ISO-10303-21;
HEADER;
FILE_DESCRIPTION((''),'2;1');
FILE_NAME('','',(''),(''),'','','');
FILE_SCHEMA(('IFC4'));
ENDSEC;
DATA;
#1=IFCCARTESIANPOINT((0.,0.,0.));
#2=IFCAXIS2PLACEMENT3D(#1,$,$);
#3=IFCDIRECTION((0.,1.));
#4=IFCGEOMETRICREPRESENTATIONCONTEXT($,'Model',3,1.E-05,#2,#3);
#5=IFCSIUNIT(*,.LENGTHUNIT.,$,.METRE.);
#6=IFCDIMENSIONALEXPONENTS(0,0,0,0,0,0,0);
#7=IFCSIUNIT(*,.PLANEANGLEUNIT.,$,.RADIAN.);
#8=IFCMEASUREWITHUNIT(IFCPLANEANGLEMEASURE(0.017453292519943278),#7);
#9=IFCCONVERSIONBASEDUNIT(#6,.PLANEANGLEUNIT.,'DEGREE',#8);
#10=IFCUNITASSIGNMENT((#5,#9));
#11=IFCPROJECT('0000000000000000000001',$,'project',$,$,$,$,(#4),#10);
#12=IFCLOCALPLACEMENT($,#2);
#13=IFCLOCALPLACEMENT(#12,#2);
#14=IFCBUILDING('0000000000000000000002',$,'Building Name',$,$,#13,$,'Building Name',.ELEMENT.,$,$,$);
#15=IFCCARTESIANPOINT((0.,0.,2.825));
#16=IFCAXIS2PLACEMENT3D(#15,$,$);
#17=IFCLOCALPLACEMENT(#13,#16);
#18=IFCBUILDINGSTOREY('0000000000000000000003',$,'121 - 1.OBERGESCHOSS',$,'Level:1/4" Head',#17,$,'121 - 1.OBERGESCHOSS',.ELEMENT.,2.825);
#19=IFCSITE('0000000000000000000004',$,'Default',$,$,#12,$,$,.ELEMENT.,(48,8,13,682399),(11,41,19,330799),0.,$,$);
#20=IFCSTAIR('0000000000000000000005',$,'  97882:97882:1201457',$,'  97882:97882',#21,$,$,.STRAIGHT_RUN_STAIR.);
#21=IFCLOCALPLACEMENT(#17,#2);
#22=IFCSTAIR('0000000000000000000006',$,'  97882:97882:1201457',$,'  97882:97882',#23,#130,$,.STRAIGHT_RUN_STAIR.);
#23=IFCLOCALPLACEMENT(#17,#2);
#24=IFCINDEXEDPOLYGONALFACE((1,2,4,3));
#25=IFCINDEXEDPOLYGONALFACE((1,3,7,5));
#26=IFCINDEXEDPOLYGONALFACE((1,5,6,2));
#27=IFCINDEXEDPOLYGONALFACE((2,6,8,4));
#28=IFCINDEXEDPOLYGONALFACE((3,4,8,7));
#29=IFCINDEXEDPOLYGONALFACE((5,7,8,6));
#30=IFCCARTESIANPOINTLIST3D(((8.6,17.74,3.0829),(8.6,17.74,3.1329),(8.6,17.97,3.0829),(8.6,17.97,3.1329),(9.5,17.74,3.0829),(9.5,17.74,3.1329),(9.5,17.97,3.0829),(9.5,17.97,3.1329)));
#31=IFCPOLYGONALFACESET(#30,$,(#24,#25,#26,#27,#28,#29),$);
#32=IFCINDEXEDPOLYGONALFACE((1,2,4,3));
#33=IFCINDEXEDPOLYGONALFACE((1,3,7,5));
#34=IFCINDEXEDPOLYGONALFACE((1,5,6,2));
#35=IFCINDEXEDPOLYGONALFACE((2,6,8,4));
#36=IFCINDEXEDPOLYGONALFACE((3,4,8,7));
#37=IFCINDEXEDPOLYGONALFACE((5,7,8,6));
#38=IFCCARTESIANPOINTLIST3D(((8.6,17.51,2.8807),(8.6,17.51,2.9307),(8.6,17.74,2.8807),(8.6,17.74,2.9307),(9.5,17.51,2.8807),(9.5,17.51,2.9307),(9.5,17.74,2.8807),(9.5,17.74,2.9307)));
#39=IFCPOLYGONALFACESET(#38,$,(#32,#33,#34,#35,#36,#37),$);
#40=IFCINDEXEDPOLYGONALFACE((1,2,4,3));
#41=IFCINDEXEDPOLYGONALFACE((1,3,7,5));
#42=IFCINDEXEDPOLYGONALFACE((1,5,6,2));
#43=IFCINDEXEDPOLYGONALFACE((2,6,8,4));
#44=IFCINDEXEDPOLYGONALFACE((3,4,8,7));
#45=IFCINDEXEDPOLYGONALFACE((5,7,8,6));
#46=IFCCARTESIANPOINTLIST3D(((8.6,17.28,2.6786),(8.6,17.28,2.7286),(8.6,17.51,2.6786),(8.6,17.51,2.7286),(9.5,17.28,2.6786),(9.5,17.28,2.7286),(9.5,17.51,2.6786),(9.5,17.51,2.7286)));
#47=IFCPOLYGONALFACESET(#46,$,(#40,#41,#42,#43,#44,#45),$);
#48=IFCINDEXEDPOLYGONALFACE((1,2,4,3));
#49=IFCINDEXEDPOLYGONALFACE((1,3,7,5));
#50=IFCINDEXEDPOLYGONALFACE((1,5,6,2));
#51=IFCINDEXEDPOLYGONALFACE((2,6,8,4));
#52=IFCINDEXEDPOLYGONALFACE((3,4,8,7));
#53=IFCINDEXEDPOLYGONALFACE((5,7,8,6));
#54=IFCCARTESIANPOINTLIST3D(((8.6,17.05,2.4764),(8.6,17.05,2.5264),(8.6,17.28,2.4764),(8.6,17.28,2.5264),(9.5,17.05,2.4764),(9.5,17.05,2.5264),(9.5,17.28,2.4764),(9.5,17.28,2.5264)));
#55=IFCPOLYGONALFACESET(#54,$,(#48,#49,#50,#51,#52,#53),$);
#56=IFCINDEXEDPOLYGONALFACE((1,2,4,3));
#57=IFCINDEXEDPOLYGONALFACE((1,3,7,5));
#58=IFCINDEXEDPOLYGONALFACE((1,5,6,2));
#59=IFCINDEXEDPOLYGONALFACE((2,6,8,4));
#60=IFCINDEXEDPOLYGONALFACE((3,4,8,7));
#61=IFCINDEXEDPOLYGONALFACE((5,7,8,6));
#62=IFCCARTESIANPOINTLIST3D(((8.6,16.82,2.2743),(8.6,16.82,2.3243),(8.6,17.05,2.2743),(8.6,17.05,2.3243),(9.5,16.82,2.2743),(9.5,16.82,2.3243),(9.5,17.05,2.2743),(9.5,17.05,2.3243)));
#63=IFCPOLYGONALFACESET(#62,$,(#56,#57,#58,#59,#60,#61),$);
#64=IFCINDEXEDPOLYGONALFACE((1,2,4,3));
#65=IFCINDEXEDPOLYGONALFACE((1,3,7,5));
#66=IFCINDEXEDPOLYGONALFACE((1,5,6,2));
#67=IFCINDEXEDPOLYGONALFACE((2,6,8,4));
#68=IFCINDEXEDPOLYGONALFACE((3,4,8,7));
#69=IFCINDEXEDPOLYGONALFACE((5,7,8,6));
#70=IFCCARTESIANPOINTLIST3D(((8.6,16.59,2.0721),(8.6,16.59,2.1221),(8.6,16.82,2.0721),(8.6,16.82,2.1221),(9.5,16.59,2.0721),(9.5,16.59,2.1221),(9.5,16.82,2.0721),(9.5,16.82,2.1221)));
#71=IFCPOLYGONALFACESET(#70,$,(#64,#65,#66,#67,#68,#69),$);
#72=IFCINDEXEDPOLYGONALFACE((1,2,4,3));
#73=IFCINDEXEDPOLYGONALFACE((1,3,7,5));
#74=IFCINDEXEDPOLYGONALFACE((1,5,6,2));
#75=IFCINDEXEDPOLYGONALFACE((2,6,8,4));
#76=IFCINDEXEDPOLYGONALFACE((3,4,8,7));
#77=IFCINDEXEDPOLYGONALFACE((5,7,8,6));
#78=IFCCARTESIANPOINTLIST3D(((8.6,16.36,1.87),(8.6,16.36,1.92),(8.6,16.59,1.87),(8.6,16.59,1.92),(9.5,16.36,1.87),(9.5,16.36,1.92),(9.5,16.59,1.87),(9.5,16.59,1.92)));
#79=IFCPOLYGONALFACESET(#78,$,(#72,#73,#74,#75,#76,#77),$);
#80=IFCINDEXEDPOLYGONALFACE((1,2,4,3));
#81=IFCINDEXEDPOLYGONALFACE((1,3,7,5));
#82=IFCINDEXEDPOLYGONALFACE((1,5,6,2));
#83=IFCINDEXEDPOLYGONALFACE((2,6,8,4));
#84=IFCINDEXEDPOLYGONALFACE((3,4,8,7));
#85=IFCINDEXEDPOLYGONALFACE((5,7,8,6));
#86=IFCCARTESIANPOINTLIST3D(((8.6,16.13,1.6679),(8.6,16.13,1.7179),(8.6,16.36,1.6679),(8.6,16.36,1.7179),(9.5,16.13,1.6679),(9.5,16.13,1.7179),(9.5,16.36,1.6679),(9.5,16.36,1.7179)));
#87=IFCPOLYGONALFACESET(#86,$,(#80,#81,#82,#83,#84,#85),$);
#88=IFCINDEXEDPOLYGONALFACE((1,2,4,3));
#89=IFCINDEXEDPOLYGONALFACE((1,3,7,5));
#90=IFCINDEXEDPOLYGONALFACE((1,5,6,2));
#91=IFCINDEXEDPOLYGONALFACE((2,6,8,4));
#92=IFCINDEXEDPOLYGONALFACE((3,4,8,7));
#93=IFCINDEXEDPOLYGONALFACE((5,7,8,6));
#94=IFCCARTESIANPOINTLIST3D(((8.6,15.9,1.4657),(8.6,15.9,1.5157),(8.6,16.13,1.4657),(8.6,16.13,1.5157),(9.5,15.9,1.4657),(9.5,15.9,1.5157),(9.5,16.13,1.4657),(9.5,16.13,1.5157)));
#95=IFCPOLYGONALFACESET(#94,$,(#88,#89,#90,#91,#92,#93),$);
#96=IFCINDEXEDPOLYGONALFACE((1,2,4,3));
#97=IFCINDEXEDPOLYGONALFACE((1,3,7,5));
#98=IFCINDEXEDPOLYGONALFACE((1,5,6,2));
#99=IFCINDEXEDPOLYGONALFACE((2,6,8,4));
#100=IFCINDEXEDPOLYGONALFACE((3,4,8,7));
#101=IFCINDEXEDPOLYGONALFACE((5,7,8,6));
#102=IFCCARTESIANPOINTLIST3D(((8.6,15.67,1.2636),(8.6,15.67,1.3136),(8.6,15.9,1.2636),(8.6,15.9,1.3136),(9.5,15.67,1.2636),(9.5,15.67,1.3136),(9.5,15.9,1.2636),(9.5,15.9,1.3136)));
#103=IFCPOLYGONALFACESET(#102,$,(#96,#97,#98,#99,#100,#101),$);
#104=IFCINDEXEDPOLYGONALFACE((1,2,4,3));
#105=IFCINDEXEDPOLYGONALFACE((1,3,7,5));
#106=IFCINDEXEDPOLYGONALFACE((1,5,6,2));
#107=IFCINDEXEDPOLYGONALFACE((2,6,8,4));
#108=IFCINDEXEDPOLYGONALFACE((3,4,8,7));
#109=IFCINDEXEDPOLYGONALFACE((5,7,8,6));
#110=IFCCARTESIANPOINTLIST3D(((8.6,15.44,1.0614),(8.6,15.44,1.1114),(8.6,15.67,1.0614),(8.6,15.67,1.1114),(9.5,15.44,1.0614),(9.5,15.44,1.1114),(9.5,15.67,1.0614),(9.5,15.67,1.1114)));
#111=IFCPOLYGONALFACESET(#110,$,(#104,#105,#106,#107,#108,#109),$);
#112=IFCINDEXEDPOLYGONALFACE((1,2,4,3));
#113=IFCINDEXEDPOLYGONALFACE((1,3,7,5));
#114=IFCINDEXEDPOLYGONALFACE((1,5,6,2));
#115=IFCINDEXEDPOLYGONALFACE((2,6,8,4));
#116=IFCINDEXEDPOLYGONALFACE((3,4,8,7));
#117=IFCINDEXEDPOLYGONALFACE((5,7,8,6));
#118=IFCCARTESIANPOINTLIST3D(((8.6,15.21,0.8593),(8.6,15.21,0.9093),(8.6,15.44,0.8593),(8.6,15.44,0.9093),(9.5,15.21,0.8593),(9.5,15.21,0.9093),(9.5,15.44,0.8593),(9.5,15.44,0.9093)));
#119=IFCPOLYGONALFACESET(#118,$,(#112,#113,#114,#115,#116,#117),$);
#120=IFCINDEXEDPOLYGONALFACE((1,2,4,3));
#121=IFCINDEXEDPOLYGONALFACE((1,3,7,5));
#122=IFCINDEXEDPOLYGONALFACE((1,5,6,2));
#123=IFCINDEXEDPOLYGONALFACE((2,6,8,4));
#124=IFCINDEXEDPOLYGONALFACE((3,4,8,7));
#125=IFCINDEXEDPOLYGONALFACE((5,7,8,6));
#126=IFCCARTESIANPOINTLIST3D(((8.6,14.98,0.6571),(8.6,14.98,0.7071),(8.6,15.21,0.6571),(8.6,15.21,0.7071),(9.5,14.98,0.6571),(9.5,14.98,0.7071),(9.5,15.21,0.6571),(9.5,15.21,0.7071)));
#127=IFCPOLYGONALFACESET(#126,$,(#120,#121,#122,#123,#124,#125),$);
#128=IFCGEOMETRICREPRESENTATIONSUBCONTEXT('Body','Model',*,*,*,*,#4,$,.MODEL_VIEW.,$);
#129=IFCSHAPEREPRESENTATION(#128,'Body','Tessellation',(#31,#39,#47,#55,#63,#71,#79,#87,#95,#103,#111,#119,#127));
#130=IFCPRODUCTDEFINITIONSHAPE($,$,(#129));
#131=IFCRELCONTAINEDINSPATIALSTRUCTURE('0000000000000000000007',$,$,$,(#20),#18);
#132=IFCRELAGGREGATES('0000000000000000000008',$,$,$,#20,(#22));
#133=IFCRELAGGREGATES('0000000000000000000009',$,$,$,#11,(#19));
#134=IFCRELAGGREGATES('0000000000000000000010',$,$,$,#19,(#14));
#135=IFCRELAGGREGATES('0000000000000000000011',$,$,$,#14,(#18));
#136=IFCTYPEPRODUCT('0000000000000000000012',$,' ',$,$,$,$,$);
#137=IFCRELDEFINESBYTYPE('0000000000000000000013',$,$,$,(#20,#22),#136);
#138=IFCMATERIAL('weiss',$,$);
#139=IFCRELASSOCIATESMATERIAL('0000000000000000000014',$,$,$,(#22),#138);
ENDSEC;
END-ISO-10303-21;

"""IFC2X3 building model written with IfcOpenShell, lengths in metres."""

from ifc_helpers import new_model, entity, si_unit, converted_unit, direction, frame, origin, origin_2d_with_axis, place, context, subcontext, project, spatial, rectangle, extrude, material, type_object, element, aggregate, save


model = new_model("IFC2X3")

# Units and contexts
model_context = context("Model", 3, precision=1e-05, world=origin(), true_north=direction((0.0, 1.0)))
body_context = subcontext(model_context, "Body", "Model", "MODEL_VIEW")
ifc_project = project(units=[si_unit("LENGTHUNIT", "METRE"), converted_unit("PLANEANGLEUNIT", "DEGREE", entity("IfcPlaneAngleMeasure", 0.017453292519943278), si_unit("PLANEANGLEUNIT", "RADIAN"), dimensions=[0, 0, 0, 0, 0, 0, 0])], contexts=[model_context])

# Site, building, storey
site_placement = place(None, origin())
site = spatial("IfcSite", under=ifc_project, at=site_placement, Name="Default", CompositionType="ELEMENT", RefLatitude=(48, 8, 13, 682399), RefLongitude=(11, 41, 19, 330799), RefElevation=0.0)
building_placement = place(site_placement, origin())
building = spatial("IfcBuilding", under=site, at=building_placement, Name="Building Name", LongName="Building Name", CompositionType="ELEMENT")
storey_placement = place(building_placement, frame((0.0, 0.0, 2.825)))
storey = spatial("IfcBuildingStorey", under=building, at=storey_placement, Name="121 - 1.OBERGESCHOSS", ObjectType="Level:1/4\" Head", LongName="121 - 1.OBERGESCHOSS", CompositionType="ELEMENT", Elevation=2.825)

# Stairs
ifc_material_1 = material(Name="weiss")
type_product_1 = type_object("IfcTypeProduct", Name=" ")
stair_1_placement = place(storey_placement, origin())
stair_1 = element("IfcStair", 1, at=stair_1_placement, inside=storey, type_object=type_product_1, Name="  97882:97882:1201457", ObjectType="  97882:97882", ShapeType="STRAIGHT_RUN_STAIR")
stair_2_placement = place(stair_1_placement, origin())
stair_2 = element("IfcStair", 2, at=stair_2_placement, type_object=type_product_1, material=ifc_material_1, Name="  97882:97882:1201457", ObjectType="  97882:97882", ShapeType="STRAIGHT_RUN_STAIR", context=body_context, shape_type="SweptSolid", body=[
    extrude(rectangle(XDim=0.9, YDim=0.23, at=origin_2d_with_axis()), frame((9.05, 17.855, 3.0829), z_axis=(0.0, 0.0, 1.0), x_axis=(-1.0, 0.0, 0.0)), (0.0, 0.0, 1.0), 0.05),
    extrude(rectangle(XDim=0.9, YDim=0.23, at=origin_2d_with_axis()), frame((9.05, 17.625, 2.8807), z_axis=(0.0, 0.0, 1.0), x_axis=(-1.0, 0.0, 0.0)), (0.0, 0.0, 1.0), 0.05),
    extrude(rectangle(XDim=0.9, YDim=0.23, at=origin_2d_with_axis()), frame((9.05, 17.395, 2.6786), z_axis=(0.0, 0.0, 1.0), x_axis=(-1.0, 0.0, 0.0)), (0.0, 0.0, 1.0), 0.05),
    extrude(rectangle(XDim=0.9, YDim=0.23, at=origin_2d_with_axis()), frame((9.05, 17.165, 2.4764), z_axis=(0.0, 0.0, 1.0), x_axis=(-1.0, 0.0, 0.0)), (0.0, 0.0, 1.0), 0.05),
    extrude(rectangle(XDim=0.9, YDim=0.23, at=origin_2d_with_axis()), frame((9.05, 16.935, 2.2743), z_axis=(0.0, 0.0, 1.0), x_axis=(-1.0, 0.0, 0.0)), (0.0, 0.0, 1.0), 0.05),
    extrude(rectangle(XDim=0.9, YDim=0.23, at=origin_2d_with_axis()), frame((9.05, 16.705, 2.0721), z_axis=(0.0, 0.0, 1.0), x_axis=(-1.0, 0.0, 0.0)), (0.0, 0.0, 1.0), 0.05),
    extrude(rectangle(XDim=0.9, YDim=0.23, at=origin_2d_with_axis()), frame((9.05, 16.475, 1.87), z_axis=(0.0, 0.0, 1.0), x_axis=(-1.0, 0.0, 0.0)), (0.0, 0.0, 1.0), 0.05),
    extrude(rectangle(XDim=0.9, YDim=0.23, at=origin_2d_with_axis()), frame((9.05, 16.245, 1.6679), z_axis=(0.0, 0.0, 1.0), x_axis=(-1.0, 0.0, 0.0)), (0.0, 0.0, 1.0), 0.05),
    extrude(rectangle(XDim=0.9, YDim=0.23, at=origin_2d_with_axis()), frame((9.05, 16.015, 1.4657), z_axis=(0.0, 0.0, 1.0), x_axis=(-1.0, 0.0, 0.0)), (0.0, 0.0, 1.0), 0.05),
    extrude(rectangle(XDim=0.9, YDim=0.23, at=origin_2d_with_axis()), frame((9.05, 15.785, 1.2636), z_axis=(0.0, 0.0, 1.0), x_axis=(-1.0, 0.0, 0.0)), (0.0, 0.0, 1.0), 0.05),
    extrude(rectangle(XDim=0.9, YDim=0.23, at=origin_2d_with_axis()), frame((9.05, 15.555, 1.0614), z_axis=(0.0, 0.0, 1.0), x_axis=(-1.0, 0.0, 0.0)), (0.0, 0.0, 1.0), 0.05),
    extrude(rectangle(XDim=0.9, YDim=0.23, at=origin_2d_with_axis()), frame((9.05, 15.325, 0.8593), z_axis=(0.0, 0.0, 1.0), x_axis=(-1.0, 0.0, 0.0)), (0.0, 0.0, 1.0), 0.05),
    extrude(rectangle(XDim=0.9, YDim=0.23, at=origin_2d_with_axis()), frame((9.05, 15.095, 0.6571), z_axis=(0.0, 0.0, 1.0), x_axis=(-1.0, 0.0, 0.0)), (0.0, 0.0, 1.0), 0.05),
])
aggregate(stair_1, [stair_2])

save(model, "model.ifc")
